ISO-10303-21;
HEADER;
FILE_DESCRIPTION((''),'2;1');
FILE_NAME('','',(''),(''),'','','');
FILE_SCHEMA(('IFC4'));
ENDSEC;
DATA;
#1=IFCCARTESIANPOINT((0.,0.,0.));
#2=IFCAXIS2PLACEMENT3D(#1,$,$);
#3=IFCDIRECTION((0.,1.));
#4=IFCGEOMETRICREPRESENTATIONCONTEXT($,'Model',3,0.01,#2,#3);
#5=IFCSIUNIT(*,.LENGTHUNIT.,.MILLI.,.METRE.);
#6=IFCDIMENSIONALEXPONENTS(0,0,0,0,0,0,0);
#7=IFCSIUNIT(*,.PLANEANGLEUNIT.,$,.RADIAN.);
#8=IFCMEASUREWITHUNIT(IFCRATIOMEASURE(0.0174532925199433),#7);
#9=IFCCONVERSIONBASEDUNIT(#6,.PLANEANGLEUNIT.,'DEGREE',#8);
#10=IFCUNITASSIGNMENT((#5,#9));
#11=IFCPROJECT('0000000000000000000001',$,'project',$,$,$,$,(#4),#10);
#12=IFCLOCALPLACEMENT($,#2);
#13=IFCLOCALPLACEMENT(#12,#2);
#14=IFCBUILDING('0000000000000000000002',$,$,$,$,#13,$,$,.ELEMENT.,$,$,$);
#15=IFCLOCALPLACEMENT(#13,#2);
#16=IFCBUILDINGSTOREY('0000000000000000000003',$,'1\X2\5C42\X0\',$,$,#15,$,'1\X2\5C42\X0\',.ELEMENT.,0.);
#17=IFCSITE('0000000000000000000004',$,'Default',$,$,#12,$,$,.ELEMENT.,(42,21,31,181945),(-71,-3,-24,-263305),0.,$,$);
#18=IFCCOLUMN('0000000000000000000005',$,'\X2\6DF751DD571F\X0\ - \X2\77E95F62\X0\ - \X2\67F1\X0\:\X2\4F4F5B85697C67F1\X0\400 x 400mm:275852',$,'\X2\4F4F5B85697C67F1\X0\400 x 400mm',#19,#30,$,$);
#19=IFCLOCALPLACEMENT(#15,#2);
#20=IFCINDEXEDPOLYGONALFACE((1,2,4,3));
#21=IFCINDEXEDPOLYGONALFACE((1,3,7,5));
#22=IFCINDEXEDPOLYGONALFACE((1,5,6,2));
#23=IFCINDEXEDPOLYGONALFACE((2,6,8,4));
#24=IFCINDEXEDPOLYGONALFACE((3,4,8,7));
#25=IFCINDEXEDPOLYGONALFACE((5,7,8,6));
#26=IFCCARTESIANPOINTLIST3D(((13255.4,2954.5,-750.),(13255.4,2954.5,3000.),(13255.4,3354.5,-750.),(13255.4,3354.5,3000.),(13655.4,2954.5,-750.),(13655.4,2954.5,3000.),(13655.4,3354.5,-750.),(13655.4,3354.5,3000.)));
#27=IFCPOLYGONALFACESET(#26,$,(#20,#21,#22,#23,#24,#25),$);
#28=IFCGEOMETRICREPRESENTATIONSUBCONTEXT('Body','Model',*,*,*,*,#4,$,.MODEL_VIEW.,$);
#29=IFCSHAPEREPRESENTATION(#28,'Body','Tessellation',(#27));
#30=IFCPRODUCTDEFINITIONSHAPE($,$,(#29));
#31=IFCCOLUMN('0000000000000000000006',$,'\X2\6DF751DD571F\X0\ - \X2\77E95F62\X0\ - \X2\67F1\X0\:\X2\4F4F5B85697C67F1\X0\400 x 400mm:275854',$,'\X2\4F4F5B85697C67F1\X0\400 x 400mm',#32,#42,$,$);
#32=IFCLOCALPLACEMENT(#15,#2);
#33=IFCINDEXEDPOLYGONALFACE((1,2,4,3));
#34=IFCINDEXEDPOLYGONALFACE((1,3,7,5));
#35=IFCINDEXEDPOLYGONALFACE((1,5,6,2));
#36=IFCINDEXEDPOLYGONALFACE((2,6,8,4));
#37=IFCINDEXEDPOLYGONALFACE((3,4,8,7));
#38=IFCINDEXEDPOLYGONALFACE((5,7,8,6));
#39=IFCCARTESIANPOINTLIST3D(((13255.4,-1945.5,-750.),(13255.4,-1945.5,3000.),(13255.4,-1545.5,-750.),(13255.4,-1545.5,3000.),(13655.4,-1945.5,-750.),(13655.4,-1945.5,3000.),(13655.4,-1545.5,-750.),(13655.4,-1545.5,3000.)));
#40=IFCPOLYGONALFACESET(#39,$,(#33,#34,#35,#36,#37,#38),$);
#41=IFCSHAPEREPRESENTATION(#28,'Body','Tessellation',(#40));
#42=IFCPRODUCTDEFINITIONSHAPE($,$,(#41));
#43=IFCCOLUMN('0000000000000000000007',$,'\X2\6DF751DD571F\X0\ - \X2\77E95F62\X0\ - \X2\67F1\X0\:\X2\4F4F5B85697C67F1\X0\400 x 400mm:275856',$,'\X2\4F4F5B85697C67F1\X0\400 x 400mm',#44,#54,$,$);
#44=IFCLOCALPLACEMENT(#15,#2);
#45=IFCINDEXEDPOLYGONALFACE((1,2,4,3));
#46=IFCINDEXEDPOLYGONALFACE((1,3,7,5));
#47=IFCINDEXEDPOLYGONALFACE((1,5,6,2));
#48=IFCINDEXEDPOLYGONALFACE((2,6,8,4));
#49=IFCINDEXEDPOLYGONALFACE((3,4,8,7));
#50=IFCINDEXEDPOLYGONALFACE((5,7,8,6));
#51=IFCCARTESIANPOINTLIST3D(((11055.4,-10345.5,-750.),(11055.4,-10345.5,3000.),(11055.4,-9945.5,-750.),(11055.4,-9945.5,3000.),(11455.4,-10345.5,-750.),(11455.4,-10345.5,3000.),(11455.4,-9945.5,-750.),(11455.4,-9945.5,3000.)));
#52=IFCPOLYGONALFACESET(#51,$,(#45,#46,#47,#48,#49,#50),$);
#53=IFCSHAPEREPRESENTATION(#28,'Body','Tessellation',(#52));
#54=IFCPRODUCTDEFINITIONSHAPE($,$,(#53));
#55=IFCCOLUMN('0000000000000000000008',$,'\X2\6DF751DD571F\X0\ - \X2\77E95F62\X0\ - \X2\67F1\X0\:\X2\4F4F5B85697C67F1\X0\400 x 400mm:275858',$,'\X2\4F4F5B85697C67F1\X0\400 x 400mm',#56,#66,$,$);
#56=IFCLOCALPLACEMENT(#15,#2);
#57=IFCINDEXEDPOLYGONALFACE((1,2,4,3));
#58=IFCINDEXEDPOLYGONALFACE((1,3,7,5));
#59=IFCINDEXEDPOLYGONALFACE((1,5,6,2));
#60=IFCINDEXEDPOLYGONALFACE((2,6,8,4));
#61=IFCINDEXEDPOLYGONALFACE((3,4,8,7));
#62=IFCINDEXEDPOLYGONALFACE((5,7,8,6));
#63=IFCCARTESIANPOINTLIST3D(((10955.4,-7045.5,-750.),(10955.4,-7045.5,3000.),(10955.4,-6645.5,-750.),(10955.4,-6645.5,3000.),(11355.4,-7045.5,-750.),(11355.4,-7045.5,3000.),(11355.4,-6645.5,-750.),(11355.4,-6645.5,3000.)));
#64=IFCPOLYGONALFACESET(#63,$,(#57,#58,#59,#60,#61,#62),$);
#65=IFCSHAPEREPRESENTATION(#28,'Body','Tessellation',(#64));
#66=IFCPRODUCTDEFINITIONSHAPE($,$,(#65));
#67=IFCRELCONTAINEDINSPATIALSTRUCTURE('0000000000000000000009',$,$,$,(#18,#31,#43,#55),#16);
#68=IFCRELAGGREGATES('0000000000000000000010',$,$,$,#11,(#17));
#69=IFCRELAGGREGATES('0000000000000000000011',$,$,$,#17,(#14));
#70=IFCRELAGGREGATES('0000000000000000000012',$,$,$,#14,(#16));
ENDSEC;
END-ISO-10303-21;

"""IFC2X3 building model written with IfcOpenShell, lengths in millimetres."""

from ifc_helpers import new_model, entity, si_unit, converted_unit, direction, frame, origin, origin_2d_with_axis, place, context, subcontext, project, spatial, rectangle, extrude, source, transform, mapped, element, save


model = new_model("IFC2X3")

# Units and contexts
model_context = context("Model", 3, precision=0.01, world=origin(), true_north=direction((0.0, 1.0)))
body_context = subcontext(model_context, "Body", "Model", "MODEL_VIEW")
ifc_project = project(units=[si_unit("LENGTHUNIT", "METRE", prefix="MILLI"), converted_unit("PLANEANGLEUNIT", "DEGREE", entity("IfcRatioMeasure", 0.0174532925199433), si_unit("PLANEANGLEUNIT", "RADIAN"), dimensions=[0, 0, 0, 0, 0, 0, 0])], contexts=[model_context])

# Site, building, storey
site_placement = place(None, origin())
site = spatial("IfcSite", under=ifc_project, at=site_placement, Name="Default", CompositionType="ELEMENT", RefLatitude=(42, 21, 31, 181945), RefLongitude=(-71, -3, -24, -263305), RefElevation=0.0)
building_placement = place(site_placement, origin())
building = spatial("IfcBuilding", under=site, at=building_placement, CompositionType="ELEMENT")
storey_placement = place(building_placement, origin())
storey = spatial("IfcBuildingStorey", under=building, at=storey_placement, Name="1层", LongName="1层", CompositionType="ELEMENT", Elevation=0.0)

# Columns
shared_shape_1 = source(origin(), body_context, "Body", "SweptSolid", [
    extrude(rectangle(XDim=400.0, YDim=400.0, at=origin_2d_with_axis()), frame((13455.4, 3154.5, -750.0), z_axis=(0.0, 0.0, 1.0), x_axis=(0.0, -1.0, 0.0)), (0.0, 0.0, 1.0), 3750.0),
])
column_1_placement = place(storey_placement, origin())
element("IfcColumn", 1, at=column_1_placement, inside=storey, Name="混凝土 - 矩形 - 柱:住宅楼柱400 x 400mm:275852", ObjectType="住宅楼柱400 x 400mm", context=body_context, shape_type="MappedRepresentation", body=[
    mapped(shared_shape_1, transform((0.0, 0.0, 0.0), scale=1.0)),
])
shared_shape_2 = source(origin(), body_context, "Body", "SweptSolid", [
    extrude(rectangle(XDim=400.0, YDim=400.0, at=origin_2d_with_axis()), frame((13455.4, -1745.5, -750.0), z_axis=(0.0, 0.0, 1.0), x_axis=(0.0, -1.0, 0.0)), (0.0, 0.0, 1.0), 3750.0),
])
column_2_placement = place(storey_placement, origin())
element("IfcColumn", 2, at=column_2_placement, inside=storey, Name="混凝土 - 矩形 - 柱:住宅楼柱400 x 400mm:275854", ObjectType="住宅楼柱400 x 400mm", context=body_context, shape_type="MappedRepresentation", body=[
    mapped(shared_shape_2, transform((0.0, 0.0, 0.0), scale=1.0)),
])
shared_shape_3 = source(origin(), body_context, "Body", "SweptSolid", [
    extrude(rectangle(XDim=400.0, YDim=400.0, at=origin_2d_with_axis()), frame((11255.4, -10145.5, -750.0), z_axis=(0.0, 0.0, 1.0), x_axis=(0.0, -1.0, 0.0)), (0.0, 0.0, 1.0), 3750.0),
])
column_3_placement = place(storey_placement, origin())
element("IfcColumn", 3, at=column_3_placement, inside=storey, Name="混凝土 - 矩形 - 柱:住宅楼柱400 x 400mm:275856", ObjectType="住宅楼柱400 x 400mm", context=body_context, shape_type="MappedRepresentation", body=[
    mapped(shared_shape_3, transform((0.0, 0.0, 0.0), scale=1.0)),
])
shared_shape_4 = source(origin(), body_context, "Body", "SweptSolid", [
    extrude(rectangle(XDim=400.0, YDim=400.0, at=origin_2d_with_axis()), frame((11155.4, -6845.5, -750.0), z_axis=(0.0, 0.0, 1.0), x_axis=(0.0, -1.0, 0.0)), (0.0, 0.0, 1.0), 3750.0),
])
column_4_placement = place(storey_placement, origin())
element("IfcColumn", 4, at=column_4_placement, inside=storey, Name="混凝土 - 矩形 - 柱:住宅楼柱400 x 400mm:275858", ObjectType="住宅楼柱400 x 400mm", context=body_context, shape_type="MappedRepresentation", body=[
    mapped(shared_shape_4, transform((0.0, 0.0, 0.0), scale=1.0)),
])

save(model, "model.ifc")
